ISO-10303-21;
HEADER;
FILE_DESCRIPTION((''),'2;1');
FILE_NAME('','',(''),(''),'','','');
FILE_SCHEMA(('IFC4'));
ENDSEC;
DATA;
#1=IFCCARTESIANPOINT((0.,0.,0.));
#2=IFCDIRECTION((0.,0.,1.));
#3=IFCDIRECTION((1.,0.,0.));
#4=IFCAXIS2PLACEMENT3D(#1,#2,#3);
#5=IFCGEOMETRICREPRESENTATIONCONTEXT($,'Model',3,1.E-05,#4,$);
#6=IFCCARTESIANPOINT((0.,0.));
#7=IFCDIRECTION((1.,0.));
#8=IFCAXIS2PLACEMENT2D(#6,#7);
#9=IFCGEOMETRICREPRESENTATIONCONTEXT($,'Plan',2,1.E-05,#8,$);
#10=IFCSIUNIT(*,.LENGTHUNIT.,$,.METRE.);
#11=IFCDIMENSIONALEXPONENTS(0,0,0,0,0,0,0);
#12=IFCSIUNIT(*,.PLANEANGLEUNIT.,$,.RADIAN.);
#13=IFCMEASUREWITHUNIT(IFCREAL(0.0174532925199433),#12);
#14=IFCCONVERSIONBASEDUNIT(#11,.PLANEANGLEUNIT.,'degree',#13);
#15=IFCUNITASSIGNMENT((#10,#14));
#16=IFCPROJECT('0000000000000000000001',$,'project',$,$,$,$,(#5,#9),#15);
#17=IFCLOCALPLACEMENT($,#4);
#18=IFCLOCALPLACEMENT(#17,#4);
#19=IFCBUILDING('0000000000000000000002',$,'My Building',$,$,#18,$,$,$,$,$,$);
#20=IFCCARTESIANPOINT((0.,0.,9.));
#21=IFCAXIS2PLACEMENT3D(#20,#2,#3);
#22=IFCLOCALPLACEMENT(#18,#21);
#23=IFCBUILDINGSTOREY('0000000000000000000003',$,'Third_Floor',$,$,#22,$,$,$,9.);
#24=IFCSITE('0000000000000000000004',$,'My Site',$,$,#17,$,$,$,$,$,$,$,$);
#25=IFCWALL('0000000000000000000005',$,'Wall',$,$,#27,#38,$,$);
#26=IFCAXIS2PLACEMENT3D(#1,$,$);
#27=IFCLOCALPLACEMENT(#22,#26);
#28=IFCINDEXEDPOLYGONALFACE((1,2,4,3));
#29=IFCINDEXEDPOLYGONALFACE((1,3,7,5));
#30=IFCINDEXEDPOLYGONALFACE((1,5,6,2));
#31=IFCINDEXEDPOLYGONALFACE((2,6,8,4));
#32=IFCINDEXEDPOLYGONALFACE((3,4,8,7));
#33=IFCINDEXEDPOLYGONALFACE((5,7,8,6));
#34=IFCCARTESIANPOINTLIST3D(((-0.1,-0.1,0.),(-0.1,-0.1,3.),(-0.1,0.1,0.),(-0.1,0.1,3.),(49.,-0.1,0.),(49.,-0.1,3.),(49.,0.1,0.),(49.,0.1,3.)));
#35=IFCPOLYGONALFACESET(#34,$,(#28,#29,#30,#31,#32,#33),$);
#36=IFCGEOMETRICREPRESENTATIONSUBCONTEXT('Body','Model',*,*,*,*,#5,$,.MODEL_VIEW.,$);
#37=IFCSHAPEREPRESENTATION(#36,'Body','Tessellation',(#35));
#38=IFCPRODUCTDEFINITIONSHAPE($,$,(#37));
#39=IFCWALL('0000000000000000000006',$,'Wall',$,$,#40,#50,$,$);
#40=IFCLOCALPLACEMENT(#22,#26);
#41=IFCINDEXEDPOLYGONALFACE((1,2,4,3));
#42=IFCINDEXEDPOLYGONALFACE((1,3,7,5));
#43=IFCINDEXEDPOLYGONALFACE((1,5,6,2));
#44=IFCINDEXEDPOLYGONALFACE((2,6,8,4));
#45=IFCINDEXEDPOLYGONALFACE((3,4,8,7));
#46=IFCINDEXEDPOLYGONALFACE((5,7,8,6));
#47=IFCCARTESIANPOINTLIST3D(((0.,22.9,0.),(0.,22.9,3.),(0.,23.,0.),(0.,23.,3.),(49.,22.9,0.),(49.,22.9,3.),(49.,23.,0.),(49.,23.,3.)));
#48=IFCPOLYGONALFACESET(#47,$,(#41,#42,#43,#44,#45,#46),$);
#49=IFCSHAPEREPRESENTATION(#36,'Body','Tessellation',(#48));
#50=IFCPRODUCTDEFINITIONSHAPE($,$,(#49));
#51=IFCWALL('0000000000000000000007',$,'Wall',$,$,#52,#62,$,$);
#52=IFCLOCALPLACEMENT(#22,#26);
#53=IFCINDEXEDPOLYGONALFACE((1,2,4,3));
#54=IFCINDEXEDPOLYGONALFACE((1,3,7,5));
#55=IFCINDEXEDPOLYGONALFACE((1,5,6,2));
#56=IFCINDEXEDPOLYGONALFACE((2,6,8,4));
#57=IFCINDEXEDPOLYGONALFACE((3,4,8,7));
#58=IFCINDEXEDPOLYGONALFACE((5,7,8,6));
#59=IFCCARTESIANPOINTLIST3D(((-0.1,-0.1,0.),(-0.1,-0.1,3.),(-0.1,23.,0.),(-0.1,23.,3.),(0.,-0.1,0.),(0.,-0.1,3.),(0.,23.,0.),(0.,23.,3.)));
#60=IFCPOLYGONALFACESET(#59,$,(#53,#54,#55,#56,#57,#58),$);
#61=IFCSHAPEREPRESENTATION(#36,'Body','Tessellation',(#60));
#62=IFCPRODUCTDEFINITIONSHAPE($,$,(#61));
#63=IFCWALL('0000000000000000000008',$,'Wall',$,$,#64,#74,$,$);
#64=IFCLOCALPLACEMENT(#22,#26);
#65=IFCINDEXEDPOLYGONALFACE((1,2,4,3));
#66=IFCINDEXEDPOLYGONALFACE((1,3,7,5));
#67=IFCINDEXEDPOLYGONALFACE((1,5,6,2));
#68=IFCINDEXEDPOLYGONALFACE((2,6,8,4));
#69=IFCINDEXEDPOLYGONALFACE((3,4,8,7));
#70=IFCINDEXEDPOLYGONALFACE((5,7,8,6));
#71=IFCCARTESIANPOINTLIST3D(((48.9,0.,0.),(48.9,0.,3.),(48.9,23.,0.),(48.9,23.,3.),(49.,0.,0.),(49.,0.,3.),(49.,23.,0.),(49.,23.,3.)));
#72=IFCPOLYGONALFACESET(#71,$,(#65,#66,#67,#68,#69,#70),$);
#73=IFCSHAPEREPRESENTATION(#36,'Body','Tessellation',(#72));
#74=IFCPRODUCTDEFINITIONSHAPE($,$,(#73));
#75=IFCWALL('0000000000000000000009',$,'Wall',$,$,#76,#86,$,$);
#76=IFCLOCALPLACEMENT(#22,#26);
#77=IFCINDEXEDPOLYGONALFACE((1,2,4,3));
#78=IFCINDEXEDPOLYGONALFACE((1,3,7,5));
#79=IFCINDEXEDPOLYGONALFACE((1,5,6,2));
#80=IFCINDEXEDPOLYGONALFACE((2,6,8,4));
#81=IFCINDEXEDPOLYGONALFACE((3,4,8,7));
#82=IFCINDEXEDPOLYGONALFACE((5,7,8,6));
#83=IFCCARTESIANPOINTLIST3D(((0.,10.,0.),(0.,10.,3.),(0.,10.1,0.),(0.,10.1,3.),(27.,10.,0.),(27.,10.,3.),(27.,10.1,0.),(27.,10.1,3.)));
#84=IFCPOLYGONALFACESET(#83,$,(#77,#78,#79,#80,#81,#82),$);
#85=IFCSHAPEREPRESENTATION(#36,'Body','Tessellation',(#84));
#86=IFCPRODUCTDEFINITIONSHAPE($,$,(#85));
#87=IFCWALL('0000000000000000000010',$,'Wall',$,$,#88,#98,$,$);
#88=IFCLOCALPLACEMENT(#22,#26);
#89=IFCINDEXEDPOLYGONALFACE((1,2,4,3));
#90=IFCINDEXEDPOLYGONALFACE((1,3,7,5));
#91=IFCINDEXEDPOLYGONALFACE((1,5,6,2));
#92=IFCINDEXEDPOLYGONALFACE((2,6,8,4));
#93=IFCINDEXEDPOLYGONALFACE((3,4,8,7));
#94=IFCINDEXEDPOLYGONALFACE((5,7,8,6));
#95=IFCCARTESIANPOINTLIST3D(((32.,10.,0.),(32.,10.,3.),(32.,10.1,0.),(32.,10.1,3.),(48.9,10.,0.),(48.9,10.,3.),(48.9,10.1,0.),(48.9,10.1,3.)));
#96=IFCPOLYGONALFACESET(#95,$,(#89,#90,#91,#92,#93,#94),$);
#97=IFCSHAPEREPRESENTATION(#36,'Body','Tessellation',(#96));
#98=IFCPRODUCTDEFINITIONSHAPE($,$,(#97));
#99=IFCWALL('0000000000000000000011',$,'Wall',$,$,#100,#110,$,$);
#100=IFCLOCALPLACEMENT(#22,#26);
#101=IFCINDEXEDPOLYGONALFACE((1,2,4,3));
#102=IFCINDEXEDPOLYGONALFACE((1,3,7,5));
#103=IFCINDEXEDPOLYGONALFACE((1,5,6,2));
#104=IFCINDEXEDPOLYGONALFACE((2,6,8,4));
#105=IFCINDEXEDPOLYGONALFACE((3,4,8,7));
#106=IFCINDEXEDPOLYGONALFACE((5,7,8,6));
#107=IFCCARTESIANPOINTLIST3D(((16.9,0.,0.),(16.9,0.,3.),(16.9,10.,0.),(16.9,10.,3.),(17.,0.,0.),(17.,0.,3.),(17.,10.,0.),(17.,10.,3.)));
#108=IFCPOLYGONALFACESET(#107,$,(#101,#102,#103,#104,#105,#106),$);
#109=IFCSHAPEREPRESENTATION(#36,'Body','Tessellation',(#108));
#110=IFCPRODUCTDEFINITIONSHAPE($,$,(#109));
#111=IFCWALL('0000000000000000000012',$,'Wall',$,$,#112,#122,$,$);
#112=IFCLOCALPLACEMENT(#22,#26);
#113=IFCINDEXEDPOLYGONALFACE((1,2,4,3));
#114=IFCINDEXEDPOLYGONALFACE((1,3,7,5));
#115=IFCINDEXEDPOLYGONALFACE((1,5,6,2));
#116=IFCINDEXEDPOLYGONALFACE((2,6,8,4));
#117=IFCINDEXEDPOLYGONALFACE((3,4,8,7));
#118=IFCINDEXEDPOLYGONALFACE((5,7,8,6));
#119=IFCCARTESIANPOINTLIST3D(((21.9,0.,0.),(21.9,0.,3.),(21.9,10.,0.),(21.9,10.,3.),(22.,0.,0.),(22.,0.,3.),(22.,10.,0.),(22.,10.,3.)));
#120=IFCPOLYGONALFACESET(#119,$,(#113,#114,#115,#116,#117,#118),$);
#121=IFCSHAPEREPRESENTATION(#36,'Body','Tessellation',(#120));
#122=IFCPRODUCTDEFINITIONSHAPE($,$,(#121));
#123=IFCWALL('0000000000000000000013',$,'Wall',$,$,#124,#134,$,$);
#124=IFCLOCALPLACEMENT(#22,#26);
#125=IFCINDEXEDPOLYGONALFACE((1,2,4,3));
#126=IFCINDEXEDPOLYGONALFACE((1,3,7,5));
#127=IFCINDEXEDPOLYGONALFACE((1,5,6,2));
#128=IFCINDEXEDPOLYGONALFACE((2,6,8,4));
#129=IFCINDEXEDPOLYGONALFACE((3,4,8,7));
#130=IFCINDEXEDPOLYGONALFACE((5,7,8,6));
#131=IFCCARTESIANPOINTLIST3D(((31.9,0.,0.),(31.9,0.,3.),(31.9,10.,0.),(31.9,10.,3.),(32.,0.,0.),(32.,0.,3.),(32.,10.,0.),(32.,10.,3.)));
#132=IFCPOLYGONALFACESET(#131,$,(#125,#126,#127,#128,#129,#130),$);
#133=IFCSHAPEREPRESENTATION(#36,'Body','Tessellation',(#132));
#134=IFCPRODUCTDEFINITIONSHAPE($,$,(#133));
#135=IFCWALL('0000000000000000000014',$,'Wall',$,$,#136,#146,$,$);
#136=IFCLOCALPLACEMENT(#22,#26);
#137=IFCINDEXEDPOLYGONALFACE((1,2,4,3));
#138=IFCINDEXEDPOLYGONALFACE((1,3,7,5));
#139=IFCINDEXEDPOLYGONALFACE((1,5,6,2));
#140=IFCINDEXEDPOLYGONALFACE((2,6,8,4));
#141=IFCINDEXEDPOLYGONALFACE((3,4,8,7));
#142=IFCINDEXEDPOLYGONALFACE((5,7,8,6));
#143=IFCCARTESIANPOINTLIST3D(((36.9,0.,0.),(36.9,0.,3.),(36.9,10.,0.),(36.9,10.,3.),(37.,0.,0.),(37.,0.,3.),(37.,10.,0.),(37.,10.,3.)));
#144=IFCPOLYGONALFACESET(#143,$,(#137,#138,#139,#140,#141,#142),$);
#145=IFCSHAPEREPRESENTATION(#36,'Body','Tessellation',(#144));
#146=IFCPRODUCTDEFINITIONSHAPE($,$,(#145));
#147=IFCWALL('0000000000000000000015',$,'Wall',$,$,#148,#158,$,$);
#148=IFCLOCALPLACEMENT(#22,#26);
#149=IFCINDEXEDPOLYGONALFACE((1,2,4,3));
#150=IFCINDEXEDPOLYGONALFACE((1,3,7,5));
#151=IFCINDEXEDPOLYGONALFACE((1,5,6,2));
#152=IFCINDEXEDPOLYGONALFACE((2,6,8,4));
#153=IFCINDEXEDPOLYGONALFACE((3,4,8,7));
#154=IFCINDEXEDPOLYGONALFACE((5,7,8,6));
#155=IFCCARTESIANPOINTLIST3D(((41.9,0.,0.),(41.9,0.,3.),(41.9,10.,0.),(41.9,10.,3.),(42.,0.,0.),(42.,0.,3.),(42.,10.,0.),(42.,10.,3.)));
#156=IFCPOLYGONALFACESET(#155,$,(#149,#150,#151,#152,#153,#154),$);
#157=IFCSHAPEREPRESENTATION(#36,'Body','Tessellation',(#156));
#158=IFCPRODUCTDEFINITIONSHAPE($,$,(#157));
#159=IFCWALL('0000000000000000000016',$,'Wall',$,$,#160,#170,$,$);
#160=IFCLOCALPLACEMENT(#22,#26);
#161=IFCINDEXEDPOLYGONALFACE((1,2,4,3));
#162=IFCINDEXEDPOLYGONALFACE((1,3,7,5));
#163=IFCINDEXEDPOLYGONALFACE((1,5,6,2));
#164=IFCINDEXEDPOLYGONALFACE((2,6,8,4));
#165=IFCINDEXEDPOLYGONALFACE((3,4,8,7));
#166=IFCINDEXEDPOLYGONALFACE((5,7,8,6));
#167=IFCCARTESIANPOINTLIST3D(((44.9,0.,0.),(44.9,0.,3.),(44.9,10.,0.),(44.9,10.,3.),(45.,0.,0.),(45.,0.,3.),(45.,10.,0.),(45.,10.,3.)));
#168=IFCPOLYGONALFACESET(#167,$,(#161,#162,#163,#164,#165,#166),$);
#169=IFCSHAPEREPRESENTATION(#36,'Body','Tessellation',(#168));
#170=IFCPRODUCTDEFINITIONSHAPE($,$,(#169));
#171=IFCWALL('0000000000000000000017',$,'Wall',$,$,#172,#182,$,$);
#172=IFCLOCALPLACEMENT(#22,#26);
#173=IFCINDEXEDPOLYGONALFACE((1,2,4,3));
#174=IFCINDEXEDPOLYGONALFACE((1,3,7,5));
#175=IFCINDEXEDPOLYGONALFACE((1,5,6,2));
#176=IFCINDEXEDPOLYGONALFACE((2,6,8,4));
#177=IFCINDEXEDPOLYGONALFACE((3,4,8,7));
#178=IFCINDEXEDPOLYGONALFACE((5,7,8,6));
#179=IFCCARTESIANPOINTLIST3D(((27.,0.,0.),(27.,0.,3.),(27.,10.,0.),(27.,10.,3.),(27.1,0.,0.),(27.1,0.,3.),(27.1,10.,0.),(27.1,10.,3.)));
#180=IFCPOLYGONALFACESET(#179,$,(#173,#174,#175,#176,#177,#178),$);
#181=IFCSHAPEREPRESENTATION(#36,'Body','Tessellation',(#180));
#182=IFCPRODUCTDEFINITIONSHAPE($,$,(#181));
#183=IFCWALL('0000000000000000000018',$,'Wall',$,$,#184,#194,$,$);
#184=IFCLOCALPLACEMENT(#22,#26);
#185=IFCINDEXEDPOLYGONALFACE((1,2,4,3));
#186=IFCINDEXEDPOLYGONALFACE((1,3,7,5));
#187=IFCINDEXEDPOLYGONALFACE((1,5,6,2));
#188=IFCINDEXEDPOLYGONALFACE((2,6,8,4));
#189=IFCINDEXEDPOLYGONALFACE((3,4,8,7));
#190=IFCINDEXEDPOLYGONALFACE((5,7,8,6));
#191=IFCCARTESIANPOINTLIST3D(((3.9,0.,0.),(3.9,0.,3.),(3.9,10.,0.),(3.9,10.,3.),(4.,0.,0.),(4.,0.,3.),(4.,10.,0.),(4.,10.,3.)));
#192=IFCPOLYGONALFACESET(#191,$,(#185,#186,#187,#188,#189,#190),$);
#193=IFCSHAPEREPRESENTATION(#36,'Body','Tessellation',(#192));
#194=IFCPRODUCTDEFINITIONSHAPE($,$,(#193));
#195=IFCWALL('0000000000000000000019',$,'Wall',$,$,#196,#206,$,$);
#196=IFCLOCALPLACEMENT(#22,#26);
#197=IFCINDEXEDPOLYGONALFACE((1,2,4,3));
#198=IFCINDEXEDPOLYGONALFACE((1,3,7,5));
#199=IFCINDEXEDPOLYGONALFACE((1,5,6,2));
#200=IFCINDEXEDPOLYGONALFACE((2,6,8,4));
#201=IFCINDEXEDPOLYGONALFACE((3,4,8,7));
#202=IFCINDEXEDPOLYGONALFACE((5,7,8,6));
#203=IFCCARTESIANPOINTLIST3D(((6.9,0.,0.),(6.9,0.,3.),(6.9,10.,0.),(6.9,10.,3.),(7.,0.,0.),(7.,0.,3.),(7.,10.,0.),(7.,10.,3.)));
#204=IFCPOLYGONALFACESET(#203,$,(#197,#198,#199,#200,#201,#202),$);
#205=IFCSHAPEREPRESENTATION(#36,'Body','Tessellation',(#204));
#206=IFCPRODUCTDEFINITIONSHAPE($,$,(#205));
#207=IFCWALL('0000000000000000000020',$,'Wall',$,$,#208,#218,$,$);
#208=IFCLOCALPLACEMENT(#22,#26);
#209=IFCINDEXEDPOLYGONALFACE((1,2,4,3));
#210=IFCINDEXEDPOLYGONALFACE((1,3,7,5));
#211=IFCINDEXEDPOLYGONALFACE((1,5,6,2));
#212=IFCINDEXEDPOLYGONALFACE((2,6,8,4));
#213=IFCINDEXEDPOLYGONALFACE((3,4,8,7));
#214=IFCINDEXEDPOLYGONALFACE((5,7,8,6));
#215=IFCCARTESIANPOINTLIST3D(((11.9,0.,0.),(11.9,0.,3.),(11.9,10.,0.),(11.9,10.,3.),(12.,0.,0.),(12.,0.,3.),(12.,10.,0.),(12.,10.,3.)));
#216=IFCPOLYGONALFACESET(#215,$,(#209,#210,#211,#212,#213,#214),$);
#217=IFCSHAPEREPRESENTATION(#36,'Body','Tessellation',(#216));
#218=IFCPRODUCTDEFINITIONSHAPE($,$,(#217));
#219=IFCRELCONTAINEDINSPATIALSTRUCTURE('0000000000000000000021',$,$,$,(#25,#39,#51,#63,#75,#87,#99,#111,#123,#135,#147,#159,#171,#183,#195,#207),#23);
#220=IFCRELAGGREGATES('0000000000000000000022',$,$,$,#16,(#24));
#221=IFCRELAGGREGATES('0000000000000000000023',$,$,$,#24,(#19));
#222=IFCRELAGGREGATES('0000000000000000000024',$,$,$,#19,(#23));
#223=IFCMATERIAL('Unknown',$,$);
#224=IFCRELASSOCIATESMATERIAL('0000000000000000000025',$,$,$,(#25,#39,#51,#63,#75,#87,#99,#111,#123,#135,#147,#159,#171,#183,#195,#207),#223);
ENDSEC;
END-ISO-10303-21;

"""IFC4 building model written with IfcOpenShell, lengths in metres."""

from ifc_helpers import new_model, entity, si_unit, converted_unit, frame, frame_2d, origin, origin_with_axes, origin_2d_with_axis, place, context, subcontext, project, spatial, rectangle, extrude, material, element, save


model = new_model("IFC4")

# Units and contexts
model_context = context("Model", 3, precision=1e-05, world=origin_with_axes())
plan_context = context("Plan", 2, precision=1e-05, world=origin_2d_with_axis())
body_context = subcontext(model_context, "Body", "Model", "MODEL_VIEW")
ifc_project = project(units=[si_unit("LENGTHUNIT", "METRE"), converted_unit("PLANEANGLEUNIT", "degree", entity("IfcReal", 0.0174532925199433), si_unit("PLANEANGLEUNIT", "RADIAN"), dimensions=[0, 0, 0, 0, 0, 0, 0])], contexts=[model_context, plan_context])

# Site, building, storey
site_placement = place(None, origin_with_axes())
site = spatial("IfcSite", under=ifc_project, at=site_placement, Name="My Site")
building_placement = place(site_placement, origin_with_axes())
building = spatial("IfcBuilding", under=site, at=building_placement, Name="My Building")
storey_placement = place(building_placement, frame((0.0, 0.0, 9.0), z_axis=(0.0, 0.0, 1.0), x_axis=(1.0, 0.0, 0.0)))
storey = spatial("IfcBuildingStorey", under=building, at=storey_placement, Name="Third_Floor", Elevation=9.0)

# Walls
ifc_material = material(Name="Unknown")
wall_1_placement = place(storey_placement, origin_with_axes())
element("IfcWall", 1, at=wall_1_placement, inside=storey, material=ifc_material, Name="Wall", context=body_context, shape_type="SweptSolid", body=[
    extrude(rectangle(XDim=49.1, YDim=0.2, at=frame_2d((24.45, 0.0))), origin(), (0.0, 0.0, 1.0), 3.0),
])
wall_2_placement = place(storey_placement, origin_with_axes())
element("IfcWall", 2, at=wall_2_placement, inside=storey, material=ifc_material, Name="Wall", context=body_context, shape_type="SweptSolid", body=[
    extrude(rectangle(XDim=49.0, YDim=0.1, at=frame_2d((24.5, 22.95))), origin(), (0.0, 0.0, 1.0), 3.0),
])
wall_3_placement = place(storey_placement, origin_with_axes())
element("IfcWall", 3, at=wall_3_placement, inside=storey, material=ifc_material, Name="Wall", context=body_context, shape_type="SweptSolid", body=[
    extrude(rectangle(XDim=0.1, YDim=23.1, at=frame_2d((-0.05, 11.45))), origin(), (0.0, 0.0, 1.0), 3.0),
])
wall_4_placement = place(storey_placement, origin_with_axes())
element("IfcWall", 4, at=wall_4_placement, inside=storey, material=ifc_material, Name="Wall", context=body_context, shape_type="SweptSolid", body=[
    extrude(rectangle(XDim=0.1, YDim=23.0, at=frame_2d((48.95, 11.5))), origin(), (0.0, 0.0, 1.0), 3.0),
])
wall_5_placement = place(storey_placement, origin_with_axes())
element("IfcWall", 5, at=wall_5_placement, inside=storey, material=ifc_material, Name="Wall", context=body_context, shape_type="SweptSolid", body=[
    extrude(rectangle(XDim=27.0, YDim=0.1, at=frame_2d((13.5, 10.05))), origin(), (0.0, 0.0, 1.0), 3.0),
])
wall_6_placement = place(storey_placement, origin_with_axes())
element("IfcWall", 6, at=wall_6_placement, inside=storey, material=ifc_material, Name="Wall", context=body_context, shape_type="SweptSolid", body=[
    extrude(rectangle(XDim=16.9, YDim=0.1, at=frame_2d((40.45, 10.05))), origin(), (0.0, 0.0, 1.0), 3.0),
])
wall_7_placement = place(storey_placement, origin_with_axes())
element("IfcWall", 7, at=wall_7_placement, inside=storey, material=ifc_material, Name="Wall", context=body_context, shape_type="SweptSolid", body=[
    extrude(rectangle(XDim=0.1, YDim=10.0, at=frame_2d((16.95, 5.0))), origin(), (0.0, 0.0, 1.0), 3.0),
])
wall_8_placement = place(storey_placement, origin_with_axes())
element("IfcWall", 8, at=wall_8_placement, inside=storey, material=ifc_material, Name="Wall", context=body_context, shape_type="SweptSolid", body=[
    extrude(rectangle(XDim=0.1, YDim=10.0, at=frame_2d((21.95, 5.0))), origin(), (0.0, 0.0, 1.0), 3.0),
])
wall_9_placement = place(storey_placement, origin_with_axes())
element("IfcWall", 9, at=wall_9_placement, inside=storey, material=ifc_material, Name="Wall", context=body_context, shape_type="SweptSolid", body=[
    extrude(rectangle(XDim=0.1, YDim=10.0, at=frame_2d((31.95, 5.0))), origin(), (0.0, 0.0, 1.0), 3.0),
])
wall_10_placement = place(storey_placement, origin_with_axes())
element("IfcWall", 10, at=wall_10_placement, inside=storey, material=ifc_material, Name="Wall", context=body_context, shape_type="SweptSolid", body=[
    extrude(rectangle(XDim=0.1, YDim=10.0, at=frame_2d((36.95, 5.0))), origin(), (0.0, 0.0, 1.0), 3.0),
])
wall_11_placement = place(storey_placement, origin_with_axes())
element("IfcWall", 11, at=wall_11_placement, inside=storey, material=ifc_material, Name="Wall", context=body_context, shape_type="SweptSolid", body=[
    extrude(rectangle(XDim=0.1, YDim=10.0, at=frame_2d((41.95, 5.0))), origin(), (0.0, 0.0, 1.0), 3.0),
])
wall_12_placement = place(storey_placement, origin_with_axes())
element("IfcWall", 12, at=wall_12_placement, inside=storey, material=ifc_material, Name="Wall", context=body_context, shape_type="SweptSolid", body=[
    extrude(rectangle(XDim=0.1, YDim=10.0, at=frame_2d((44.95, 5.0))), origin(), (0.0, 0.0, 1.0), 3.0),
])
wall_13_placement = place(storey_placement, origin_with_axes())
element("IfcWall", 13, at=wall_13_placement, inside=storey, material=ifc_material, Name="Wall", context=body_context, shape_type="SweptSolid", body=[
    extrude(rectangle(XDim=0.1, YDim=10.0, at=frame_2d((27.05, 5.0))), origin(), (0.0, 0.0, 1.0), 3.0),
])
wall_14_placement = place(storey_placement, origin_with_axes())
element("IfcWall", 14, at=wall_14_placement, inside=storey, material=ifc_material, Name="Wall", context=body_context, shape_type="SweptSolid", body=[
    extrude(rectangle(XDim=0.1, YDim=10.0, at=frame_2d((3.95, 5.0))), origin(), (0.0, 0.0, 1.0), 3.0),
])
wall_15_placement = place(storey_placement, origin_with_axes())
element("IfcWall", 15, at=wall_15_placement, inside=storey, material=ifc_material, Name="Wall", context=body_context, shape_type="SweptSolid", body=[
    extrude(rectangle(XDim=0.1, YDim=10.0, at=frame_2d((6.95, 5.0))), origin(), (0.0, 0.0, 1.0), 3.0),
])
wall_16_placement = place(storey_placement, origin_with_axes())
element("IfcWall", 16, at=wall_16_placement, inside=storey, material=ifc_material, Name="Wall", context=body_context, shape_type="SweptSolid", body=[
    extrude(rectangle(XDim=0.1, YDim=10.0, at=frame_2d((11.95, 5.0))), origin(), (0.0, 0.0, 1.0), 3.0),
])

save(model, "model.ifc")
